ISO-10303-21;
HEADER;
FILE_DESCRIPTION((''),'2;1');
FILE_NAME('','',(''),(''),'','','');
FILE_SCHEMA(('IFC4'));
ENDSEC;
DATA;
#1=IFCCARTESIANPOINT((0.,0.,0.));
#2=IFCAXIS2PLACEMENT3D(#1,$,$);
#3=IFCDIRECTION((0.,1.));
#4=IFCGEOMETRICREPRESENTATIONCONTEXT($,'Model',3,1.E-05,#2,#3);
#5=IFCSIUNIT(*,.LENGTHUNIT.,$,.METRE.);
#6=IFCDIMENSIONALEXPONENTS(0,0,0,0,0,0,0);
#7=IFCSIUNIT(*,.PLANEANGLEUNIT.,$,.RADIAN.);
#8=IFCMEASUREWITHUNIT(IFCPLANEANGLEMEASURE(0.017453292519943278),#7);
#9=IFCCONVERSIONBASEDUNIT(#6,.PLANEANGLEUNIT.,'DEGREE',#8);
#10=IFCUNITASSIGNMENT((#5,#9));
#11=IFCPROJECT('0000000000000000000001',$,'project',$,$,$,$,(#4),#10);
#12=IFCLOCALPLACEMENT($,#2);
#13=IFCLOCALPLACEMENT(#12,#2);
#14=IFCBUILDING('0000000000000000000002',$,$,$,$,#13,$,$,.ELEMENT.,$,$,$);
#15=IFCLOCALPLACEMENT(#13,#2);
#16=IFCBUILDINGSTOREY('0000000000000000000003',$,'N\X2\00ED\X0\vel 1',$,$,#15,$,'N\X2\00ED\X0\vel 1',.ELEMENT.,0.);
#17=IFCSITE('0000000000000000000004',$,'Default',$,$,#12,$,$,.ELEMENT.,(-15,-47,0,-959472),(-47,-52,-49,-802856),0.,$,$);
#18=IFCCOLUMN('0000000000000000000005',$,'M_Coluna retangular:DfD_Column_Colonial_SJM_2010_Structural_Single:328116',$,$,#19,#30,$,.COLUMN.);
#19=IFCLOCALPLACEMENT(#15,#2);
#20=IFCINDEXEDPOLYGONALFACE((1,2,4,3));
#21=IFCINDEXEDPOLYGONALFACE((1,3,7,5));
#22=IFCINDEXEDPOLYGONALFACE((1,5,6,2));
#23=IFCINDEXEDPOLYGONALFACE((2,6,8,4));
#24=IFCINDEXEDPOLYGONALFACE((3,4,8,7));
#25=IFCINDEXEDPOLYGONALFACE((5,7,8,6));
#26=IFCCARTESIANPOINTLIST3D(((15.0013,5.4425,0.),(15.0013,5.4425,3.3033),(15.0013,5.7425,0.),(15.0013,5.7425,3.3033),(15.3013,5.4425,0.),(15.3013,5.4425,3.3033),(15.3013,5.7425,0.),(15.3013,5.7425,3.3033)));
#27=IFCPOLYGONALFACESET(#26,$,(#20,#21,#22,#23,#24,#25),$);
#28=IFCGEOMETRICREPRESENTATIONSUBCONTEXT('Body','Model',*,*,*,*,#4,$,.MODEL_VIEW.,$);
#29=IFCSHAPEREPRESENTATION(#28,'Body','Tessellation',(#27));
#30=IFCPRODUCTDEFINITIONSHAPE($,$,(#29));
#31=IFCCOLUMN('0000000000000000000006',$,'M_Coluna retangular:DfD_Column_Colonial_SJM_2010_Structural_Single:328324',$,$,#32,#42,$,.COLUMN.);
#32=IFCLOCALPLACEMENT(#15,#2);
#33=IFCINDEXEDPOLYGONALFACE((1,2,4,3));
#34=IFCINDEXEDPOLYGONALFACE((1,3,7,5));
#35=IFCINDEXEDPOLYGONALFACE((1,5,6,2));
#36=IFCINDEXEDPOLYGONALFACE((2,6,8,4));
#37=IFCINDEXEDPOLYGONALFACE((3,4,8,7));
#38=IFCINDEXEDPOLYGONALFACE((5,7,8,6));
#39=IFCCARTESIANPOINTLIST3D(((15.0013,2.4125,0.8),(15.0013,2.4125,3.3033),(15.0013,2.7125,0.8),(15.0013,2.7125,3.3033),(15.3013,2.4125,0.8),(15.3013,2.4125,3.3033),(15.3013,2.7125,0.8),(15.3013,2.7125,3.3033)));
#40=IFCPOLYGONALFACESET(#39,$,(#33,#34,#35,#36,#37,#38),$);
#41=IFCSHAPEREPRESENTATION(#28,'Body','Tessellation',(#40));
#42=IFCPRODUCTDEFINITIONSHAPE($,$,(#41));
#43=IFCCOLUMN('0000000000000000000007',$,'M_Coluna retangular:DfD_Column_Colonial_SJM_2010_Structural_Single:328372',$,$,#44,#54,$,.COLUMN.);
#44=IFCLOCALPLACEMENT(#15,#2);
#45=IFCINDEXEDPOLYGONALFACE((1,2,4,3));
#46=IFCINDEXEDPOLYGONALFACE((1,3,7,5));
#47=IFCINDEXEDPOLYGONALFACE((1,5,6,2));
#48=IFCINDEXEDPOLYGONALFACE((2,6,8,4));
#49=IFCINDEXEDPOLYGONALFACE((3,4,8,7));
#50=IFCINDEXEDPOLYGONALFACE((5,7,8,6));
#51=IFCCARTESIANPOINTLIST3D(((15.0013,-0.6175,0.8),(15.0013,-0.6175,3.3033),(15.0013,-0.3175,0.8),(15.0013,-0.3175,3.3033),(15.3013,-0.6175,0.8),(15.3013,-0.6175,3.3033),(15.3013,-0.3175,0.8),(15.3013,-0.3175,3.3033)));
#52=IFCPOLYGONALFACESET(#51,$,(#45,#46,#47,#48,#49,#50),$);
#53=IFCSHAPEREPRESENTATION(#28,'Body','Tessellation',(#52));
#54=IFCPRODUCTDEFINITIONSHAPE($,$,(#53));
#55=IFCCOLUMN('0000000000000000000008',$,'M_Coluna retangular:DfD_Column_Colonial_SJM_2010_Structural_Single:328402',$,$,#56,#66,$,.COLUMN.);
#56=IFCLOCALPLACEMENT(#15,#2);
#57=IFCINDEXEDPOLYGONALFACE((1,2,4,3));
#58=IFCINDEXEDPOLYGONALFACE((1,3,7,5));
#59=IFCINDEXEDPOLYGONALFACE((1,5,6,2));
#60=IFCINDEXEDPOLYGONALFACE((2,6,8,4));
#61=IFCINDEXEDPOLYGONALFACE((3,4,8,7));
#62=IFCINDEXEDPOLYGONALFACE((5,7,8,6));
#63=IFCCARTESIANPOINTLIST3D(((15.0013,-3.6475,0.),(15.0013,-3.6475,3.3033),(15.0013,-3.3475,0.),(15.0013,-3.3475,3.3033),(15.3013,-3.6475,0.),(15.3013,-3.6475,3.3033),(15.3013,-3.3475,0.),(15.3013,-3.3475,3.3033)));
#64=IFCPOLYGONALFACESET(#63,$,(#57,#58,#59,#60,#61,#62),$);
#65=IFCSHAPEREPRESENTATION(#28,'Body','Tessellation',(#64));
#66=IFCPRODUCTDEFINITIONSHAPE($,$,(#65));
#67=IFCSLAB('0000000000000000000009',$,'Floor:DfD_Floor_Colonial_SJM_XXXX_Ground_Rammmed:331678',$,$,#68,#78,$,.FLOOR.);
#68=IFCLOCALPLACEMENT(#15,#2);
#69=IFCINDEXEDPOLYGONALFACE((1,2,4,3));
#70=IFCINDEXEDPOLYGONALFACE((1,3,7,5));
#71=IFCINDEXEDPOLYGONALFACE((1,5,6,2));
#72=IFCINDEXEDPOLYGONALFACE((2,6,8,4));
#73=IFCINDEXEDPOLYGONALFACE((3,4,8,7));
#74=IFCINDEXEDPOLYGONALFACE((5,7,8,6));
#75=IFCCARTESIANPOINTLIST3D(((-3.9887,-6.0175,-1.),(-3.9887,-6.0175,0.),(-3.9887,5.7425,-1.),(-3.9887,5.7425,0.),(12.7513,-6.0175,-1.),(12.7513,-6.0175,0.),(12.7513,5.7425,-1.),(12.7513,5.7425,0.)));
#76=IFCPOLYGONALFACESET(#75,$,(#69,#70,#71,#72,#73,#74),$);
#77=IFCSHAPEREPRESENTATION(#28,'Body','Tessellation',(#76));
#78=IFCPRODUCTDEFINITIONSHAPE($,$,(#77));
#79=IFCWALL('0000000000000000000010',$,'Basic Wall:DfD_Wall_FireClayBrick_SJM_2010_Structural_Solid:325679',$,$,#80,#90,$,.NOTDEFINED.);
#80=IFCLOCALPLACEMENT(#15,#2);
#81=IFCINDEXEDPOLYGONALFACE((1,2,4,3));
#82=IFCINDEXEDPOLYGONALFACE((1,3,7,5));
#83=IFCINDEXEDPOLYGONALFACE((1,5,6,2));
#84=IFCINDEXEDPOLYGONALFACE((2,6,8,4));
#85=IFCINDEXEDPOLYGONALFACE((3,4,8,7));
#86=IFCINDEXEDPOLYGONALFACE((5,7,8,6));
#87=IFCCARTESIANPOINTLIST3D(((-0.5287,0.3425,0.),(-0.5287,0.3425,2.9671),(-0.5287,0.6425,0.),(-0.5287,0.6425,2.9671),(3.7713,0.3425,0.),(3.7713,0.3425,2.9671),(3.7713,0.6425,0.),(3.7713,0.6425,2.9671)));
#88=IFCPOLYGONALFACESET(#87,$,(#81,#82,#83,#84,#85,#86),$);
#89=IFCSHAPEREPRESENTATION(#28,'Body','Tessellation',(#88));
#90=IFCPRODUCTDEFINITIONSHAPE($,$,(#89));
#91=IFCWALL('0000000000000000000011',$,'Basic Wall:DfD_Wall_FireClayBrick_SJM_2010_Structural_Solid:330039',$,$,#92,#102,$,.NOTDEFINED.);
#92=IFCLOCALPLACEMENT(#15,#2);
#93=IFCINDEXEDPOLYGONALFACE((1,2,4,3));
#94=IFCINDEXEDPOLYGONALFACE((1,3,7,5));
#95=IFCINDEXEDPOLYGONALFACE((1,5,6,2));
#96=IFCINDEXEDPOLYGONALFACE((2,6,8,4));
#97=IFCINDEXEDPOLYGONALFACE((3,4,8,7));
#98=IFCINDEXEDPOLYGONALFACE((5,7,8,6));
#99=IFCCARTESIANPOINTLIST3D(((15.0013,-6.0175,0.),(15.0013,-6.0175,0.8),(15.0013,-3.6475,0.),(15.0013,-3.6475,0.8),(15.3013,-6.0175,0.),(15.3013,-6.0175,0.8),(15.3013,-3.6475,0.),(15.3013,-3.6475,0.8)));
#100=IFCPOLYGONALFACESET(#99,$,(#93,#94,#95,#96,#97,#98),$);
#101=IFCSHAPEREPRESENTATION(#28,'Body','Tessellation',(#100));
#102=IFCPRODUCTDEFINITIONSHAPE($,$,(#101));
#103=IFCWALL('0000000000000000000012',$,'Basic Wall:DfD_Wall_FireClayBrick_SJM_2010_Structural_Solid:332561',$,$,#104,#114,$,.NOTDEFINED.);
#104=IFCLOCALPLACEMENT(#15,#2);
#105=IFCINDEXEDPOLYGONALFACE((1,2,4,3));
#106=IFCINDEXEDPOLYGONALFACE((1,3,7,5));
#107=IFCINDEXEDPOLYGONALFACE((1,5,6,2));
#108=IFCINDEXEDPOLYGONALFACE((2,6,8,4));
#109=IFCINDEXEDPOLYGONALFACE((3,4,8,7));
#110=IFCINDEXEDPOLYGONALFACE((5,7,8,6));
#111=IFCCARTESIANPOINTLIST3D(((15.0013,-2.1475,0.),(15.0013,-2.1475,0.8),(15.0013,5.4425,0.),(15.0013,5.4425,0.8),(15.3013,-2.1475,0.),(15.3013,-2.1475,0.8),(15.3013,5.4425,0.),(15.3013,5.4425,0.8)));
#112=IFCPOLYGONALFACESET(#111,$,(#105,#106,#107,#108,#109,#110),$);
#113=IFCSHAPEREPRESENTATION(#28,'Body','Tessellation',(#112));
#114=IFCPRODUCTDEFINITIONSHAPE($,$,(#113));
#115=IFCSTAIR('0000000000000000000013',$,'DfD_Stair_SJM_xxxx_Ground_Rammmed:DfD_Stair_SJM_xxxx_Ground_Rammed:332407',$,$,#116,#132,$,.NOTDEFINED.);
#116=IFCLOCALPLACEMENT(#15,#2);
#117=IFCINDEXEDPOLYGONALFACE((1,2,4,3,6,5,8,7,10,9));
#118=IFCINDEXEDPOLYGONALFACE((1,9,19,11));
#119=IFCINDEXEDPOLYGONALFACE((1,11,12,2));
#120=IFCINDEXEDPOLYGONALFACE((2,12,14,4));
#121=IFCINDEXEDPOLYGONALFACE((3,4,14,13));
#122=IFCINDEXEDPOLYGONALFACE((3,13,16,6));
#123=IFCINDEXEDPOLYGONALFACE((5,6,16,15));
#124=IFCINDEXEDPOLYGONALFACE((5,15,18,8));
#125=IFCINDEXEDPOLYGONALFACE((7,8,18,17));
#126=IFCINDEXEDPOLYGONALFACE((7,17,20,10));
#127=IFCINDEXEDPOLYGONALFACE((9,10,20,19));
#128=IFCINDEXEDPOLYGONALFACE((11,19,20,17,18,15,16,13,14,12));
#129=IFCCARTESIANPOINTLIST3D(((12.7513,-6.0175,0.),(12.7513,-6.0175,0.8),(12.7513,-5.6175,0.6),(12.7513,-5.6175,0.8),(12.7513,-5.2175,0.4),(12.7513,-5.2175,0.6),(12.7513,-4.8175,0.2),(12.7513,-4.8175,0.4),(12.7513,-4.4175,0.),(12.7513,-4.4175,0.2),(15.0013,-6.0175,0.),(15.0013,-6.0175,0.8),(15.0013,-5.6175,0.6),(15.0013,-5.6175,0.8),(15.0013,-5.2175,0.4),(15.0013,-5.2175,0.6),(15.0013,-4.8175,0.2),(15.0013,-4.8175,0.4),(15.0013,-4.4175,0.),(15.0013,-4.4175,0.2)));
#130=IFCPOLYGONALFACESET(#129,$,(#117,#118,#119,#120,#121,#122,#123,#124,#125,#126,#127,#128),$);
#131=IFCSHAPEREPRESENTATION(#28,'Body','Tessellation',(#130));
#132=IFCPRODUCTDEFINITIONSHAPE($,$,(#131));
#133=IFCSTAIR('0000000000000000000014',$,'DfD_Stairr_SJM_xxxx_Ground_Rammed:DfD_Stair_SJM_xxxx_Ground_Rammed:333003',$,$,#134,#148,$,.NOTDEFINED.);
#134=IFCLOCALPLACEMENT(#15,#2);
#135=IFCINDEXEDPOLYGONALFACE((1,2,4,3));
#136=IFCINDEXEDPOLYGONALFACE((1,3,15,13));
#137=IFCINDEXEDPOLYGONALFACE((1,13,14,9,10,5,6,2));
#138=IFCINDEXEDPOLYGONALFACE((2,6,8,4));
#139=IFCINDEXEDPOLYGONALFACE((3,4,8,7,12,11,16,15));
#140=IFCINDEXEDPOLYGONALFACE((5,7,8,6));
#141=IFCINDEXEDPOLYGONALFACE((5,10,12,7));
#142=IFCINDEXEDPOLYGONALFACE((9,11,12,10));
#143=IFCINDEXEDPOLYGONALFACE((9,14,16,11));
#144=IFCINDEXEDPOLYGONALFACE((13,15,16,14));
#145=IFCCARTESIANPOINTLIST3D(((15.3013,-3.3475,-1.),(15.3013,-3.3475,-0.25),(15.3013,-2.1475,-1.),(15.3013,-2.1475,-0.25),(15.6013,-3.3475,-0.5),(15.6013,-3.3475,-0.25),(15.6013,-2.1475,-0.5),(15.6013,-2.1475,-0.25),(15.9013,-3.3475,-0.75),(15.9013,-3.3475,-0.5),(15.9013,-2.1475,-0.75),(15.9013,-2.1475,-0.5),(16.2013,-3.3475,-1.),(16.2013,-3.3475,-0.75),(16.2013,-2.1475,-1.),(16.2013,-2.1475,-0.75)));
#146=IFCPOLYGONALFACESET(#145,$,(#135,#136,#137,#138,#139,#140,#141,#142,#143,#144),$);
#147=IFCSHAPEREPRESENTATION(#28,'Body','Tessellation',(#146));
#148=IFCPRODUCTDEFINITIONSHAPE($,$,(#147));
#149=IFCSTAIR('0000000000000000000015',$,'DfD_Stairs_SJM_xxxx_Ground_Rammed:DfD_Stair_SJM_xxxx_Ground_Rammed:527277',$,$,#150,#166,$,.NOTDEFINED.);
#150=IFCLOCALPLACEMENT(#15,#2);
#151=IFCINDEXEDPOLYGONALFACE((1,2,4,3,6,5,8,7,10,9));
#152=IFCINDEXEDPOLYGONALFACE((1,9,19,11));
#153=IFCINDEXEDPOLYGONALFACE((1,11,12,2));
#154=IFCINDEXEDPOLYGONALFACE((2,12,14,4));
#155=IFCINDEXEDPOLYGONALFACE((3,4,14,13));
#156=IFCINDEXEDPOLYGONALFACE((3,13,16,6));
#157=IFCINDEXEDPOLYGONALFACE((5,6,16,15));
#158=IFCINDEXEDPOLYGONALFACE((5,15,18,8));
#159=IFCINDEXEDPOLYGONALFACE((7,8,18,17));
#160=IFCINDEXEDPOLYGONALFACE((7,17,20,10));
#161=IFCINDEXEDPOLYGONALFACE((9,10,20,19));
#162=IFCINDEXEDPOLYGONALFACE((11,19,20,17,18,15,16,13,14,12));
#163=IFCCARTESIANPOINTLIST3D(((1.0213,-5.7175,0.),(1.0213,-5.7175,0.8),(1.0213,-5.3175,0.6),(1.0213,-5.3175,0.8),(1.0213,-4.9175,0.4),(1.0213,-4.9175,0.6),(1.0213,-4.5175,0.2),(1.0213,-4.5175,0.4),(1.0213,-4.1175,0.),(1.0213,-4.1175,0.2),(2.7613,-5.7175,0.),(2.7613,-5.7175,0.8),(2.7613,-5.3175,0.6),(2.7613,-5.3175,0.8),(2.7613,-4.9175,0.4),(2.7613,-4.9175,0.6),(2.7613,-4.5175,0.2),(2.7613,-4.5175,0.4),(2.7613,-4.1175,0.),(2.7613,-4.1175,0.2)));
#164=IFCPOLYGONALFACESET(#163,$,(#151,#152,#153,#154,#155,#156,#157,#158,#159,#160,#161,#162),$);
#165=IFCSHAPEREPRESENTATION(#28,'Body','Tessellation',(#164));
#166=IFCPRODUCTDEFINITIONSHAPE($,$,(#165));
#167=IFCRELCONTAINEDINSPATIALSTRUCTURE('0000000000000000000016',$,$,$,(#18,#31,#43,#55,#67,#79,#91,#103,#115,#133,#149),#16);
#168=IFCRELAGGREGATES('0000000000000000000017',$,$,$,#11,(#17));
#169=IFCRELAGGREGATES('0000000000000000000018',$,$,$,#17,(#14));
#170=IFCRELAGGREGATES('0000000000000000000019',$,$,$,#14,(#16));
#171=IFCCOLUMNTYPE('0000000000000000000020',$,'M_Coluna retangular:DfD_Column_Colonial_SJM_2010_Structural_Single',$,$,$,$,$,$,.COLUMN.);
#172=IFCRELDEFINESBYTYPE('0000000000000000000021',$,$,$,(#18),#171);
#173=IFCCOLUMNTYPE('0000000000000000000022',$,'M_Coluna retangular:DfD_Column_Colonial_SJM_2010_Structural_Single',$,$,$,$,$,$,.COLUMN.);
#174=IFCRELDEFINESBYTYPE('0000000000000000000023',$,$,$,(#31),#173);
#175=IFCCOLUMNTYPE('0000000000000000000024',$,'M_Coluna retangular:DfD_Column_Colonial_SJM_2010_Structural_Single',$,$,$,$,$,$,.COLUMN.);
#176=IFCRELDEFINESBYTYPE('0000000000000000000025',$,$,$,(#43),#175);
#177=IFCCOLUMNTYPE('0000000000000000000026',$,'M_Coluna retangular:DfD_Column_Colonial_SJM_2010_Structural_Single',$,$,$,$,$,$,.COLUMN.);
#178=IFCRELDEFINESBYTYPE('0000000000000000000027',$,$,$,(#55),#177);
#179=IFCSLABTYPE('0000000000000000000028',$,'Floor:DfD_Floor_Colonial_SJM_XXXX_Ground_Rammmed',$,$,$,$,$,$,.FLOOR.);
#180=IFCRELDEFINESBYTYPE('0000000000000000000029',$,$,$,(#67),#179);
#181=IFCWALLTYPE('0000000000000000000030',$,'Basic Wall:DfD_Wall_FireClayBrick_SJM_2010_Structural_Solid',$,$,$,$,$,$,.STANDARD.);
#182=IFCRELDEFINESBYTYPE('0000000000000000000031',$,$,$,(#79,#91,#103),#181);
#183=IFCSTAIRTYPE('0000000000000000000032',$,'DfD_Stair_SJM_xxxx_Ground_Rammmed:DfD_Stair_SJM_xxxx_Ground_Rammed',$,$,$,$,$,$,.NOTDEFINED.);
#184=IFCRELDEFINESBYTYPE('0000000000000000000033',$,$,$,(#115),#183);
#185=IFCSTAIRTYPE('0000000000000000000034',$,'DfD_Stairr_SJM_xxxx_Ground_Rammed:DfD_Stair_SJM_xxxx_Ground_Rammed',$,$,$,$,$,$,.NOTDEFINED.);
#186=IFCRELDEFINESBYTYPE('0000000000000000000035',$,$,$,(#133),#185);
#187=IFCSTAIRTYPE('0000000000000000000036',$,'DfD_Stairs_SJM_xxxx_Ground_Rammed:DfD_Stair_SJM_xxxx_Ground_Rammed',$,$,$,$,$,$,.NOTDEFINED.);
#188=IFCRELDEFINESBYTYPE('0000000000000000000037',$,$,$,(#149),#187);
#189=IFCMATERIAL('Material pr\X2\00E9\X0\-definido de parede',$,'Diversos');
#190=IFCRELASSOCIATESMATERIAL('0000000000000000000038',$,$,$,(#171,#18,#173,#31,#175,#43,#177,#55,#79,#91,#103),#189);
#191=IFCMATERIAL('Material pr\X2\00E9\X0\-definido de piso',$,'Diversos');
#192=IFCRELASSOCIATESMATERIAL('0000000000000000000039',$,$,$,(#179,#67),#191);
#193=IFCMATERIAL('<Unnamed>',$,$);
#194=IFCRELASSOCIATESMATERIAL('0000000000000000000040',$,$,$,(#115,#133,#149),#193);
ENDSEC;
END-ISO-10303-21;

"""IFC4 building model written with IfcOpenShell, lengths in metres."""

from ifc_helpers import new_model, entity, si_unit, converted_unit, direction, frame, origin, place, context, subcontext, project, spatial, indexed_curve, outline, extrude, source, transform, mapped, material, type_object, type_shapes, element, save


model = new_model("IFC4")

# Units and contexts
model_context = context("Model", 3, precision=1e-05, world=origin(), true_north=direction((0.0, 1.0)))
body_context = subcontext(model_context, "Body", "Model", "MODEL_VIEW")
ifc_project = project(units=[si_unit("LENGTHUNIT", "METRE"), converted_unit("PLANEANGLEUNIT", "DEGREE", entity("IfcPlaneAngleMeasure", 0.017453292519943278), si_unit("PLANEANGLEUNIT", "RADIAN"), dimensions=[0, 0, 0, 0, 0, 0, 0])], contexts=[model_context])

# Site, building, storey
site_placement = place(None, origin())
site = spatial("IfcSite", under=ifc_project, at=site_placement, Name="Default", CompositionType="ELEMENT", RefLatitude=(-15, -47, 0, -959472), RefLongitude=(-47, -52, -49, -802856), RefElevation=0.0)
building_placement = place(site_placement, origin())
building = spatial("IfcBuilding", under=site, at=building_placement, CompositionType="ELEMENT")
storey_placement = place(building_placement, origin())
storey = spatial("IfcBuildingStorey", under=building, at=storey_placement, Name="Nível 1", LongName="Nível 1", CompositionType="ELEMENT", Elevation=0.0)

# Columns
ifc_material_1 = material(Name="Material pré-definido de parede", Category="Diversos")
column_type_1 = type_object("IfcColumnType", Name="M_Coluna retangular:DfD_Column_Colonial_SJM_2010_Structural_Single", PredefinedType="COLUMN", material=ifc_material_1)
shared_shape_1 = source(origin(), body_context, "Body", "SweptSolid", [
    extrude(outline(indexed_curve([(-0.15, -0.15), (0.15, -0.15), (0.15, 0.15), (-0.15, 0.15), (-0.15, -0.15)], self_intersect=False)), frame((15.1513, 5.5925, 0.0), z_axis=(0.0, 0.0, 1.0), x_axis=(-1.0, 0.0, 0.0)), (0.0, 0.0, 1.0), 3.3033),
])
type_shapes(column_type_1, [shared_shape_1])
column_1_placement = place(storey_placement, origin())
element("IfcColumn", 1, at=column_1_placement, inside=storey, type_object=column_type_1, material=ifc_material_1, Name="M_Coluna retangular:DfD_Column_Colonial_SJM_2010_Structural_Single:328116", PredefinedType="COLUMN", context=body_context, shape_type="MappedRepresentation", body=[
    mapped(shared_shape_1, transform((0.0, 0.0, 0.0), scale=1.0)),
])
column_type_2 = type_object("IfcColumnType", Name="M_Coluna retangular:DfD_Column_Colonial_SJM_2010_Structural_Single", PredefinedType="COLUMN", material=ifc_material_1)
shared_shape_2 = source(origin(), body_context, "Body", "SweptSolid", [
    extrude(outline(indexed_curve([(-0.15, -0.15), (0.15, -0.15), (0.15, 0.15), (-0.15, 0.15), (-0.15, -0.15)], self_intersect=False)), frame((15.1513, 2.5625, 0.8), z_axis=(0.0, 0.0, 1.0), x_axis=(0.0, -1.0, 0.0)), (0.0, 0.0, 1.0), 2.5033),
])
type_shapes(column_type_2, [shared_shape_2])
column_2_placement = place(storey_placement, origin())
element("IfcColumn", 2, at=column_2_placement, inside=storey, type_object=column_type_2, material=ifc_material_1, Name="M_Coluna retangular:DfD_Column_Colonial_SJM_2010_Structural_Single:328324", PredefinedType="COLUMN", context=body_context, shape_type="MappedRepresentation", body=[
    mapped(shared_shape_2, transform((0.0, 0.0, 0.0), scale=1.0)),
])
column_type_3 = type_object("IfcColumnType", Name="M_Coluna retangular:DfD_Column_Colonial_SJM_2010_Structural_Single", PredefinedType="COLUMN", material=ifc_material_1)
shared_shape_3 = source(origin(), body_context, "Body", "SweptSolid", [
    extrude(outline(indexed_curve([(-0.15, -0.15), (0.15, -0.15), (0.15, 0.15), (-0.15, 0.15), (-0.15, -0.15)], self_intersect=False)), frame((15.1513, -0.4675, 0.8), z_axis=(0.0, 0.0, 1.0), x_axis=(0.0, -1.0, 0.0)), (0.0, 0.0, 1.0), 2.5033),
])
type_shapes(column_type_3, [shared_shape_3])
column_3_placement = place(storey_placement, origin())
element("IfcColumn", 3, at=column_3_placement, inside=storey, type_object=column_type_3, material=ifc_material_1, Name="M_Coluna retangular:DfD_Column_Colonial_SJM_2010_Structural_Single:328372", PredefinedType="COLUMN", context=body_context, shape_type="MappedRepresentation", body=[
    mapped(shared_shape_3, transform((0.0, 0.0, 0.0), scale=1.0)),
])
column_type_4 = type_object("IfcColumnType", Name="M_Coluna retangular:DfD_Column_Colonial_SJM_2010_Structural_Single", PredefinedType="COLUMN", material=ifc_material_1)
shared_shape_4 = source(origin(), body_context, "Body", "SweptSolid", [
    extrude(outline(indexed_curve([(-0.15, -0.15), (0.15, -0.15), (0.15, 0.15), (-0.15, 0.15), (-0.15, -0.15)], self_intersect=False)), frame((15.1513, -3.4975, 0.0), z_axis=(0.0, 0.0, 1.0), x_axis=(-1.0, 0.0, 0.0)), (0.0, 0.0, 1.0), 3.3033),
])
type_shapes(column_type_4, [shared_shape_4])
column_4_placement = place(storey_placement, origin())
element("IfcColumn", 4, at=column_4_placement, inside=storey, type_object=column_type_4, material=ifc_material_1, Name="M_Coluna retangular:DfD_Column_Colonial_SJM_2010_Structural_Single:328402", PredefinedType="COLUMN", context=body_context, shape_type="MappedRepresentation", body=[
    mapped(shared_shape_4, transform((0.0, 0.0, 0.0), scale=1.0)),
])

# Slab
ifc_material_2 = material(Name="Material pré-definido de piso", Category="Diversos")
slab_type = type_object("IfcSlabType", Name="Floor:DfD_Floor_Colonial_SJM_XXXX_Ground_Rammmed", PredefinedType="FLOOR", material=ifc_material_2)
slab_1_placement = place(storey_placement, origin())
element("IfcSlab", 5, at=slab_1_placement, inside=storey, type_object=slab_type, material=ifc_material_2, Name="Floor:DfD_Floor_Colonial_SJM_XXXX_Ground_Rammmed:331678", PredefinedType="FLOOR", context=body_context, shape_type="SweptSolid", body=[
    extrude(outline(indexed_curve([(-5.88, -8.37), (5.88, -8.37), (5.88, 8.37), (-5.88, 8.37), (-5.88, -8.37)], self_intersect=False)), frame((4.3813, -0.1375, 0.0), z_axis=(0.0, 0.0, -1.0), x_axis=(0.0, 1.0, 0.0)), (0.0, 0.0, 1.0), 1.0),
])

# Walls
wall_type = type_object("IfcWallType", Name="Basic Wall:DfD_Wall_FireClayBrick_SJM_2010_Structural_Solid", PredefinedType="STANDARD")
wall_1_placement = place(storey_placement, frame((-0.5287, 0.4925, 0.0)))
element("IfcWall", 6, at=wall_1_placement, inside=storey, type_object=wall_type, material=ifc_material_1, Name="Basic Wall:DfD_Wall_FireClayBrick_SJM_2010_Structural_Solid:325679", PredefinedType="NOTDEFINED", context=body_context, shape_type="SweptSolid", body=[
    extrude(outline(indexed_curve([(4.3, 0.15), (0.0, 0.15), (0.0, -0.15), (4.3, -0.15), (4.3, 0.15)], self_intersect=False)), origin(), (0.0, 0.0, 1.0), 2.9671),
])
wall_2_placement = place(storey_placement, frame((15.1513, -6.0175, 0.0), z_axis=(0.0, 0.0, 1.0), x_axis=(0.0, 1.0, 0.0)))
element("IfcWall", 7, at=wall_2_placement, inside=storey, type_object=wall_type, material=ifc_material_1, Name="Basic Wall:DfD_Wall_FireClayBrick_SJM_2010_Structural_Solid:330039", PredefinedType="NOTDEFINED", context=body_context, shape_type="SweptSolid", body=[
    extrude(outline(indexed_curve([(2.37, 0.15), (0.0, 0.15), (0.0, -0.15), (2.37, -0.15), (2.37, 0.15)], self_intersect=False)), origin(), (0.0, 0.0, 1.0), 0.8),
])
wall_3_placement = place(storey_placement, frame((15.1513, -2.1475, 0.0), z_axis=(0.0, 0.0, 1.0), x_axis=(0.0, 1.0, 0.0)))
element("IfcWall", 8, at=wall_3_placement, inside=storey, type_object=wall_type, material=ifc_material_1, Name="Basic Wall:DfD_Wall_FireClayBrick_SJM_2010_Structural_Solid:332561", PredefinedType="NOTDEFINED", context=body_context, shape_type="SweptSolid", body=[
    extrude(outline(indexed_curve([(7.59, 0.15), (0.0, 0.15), (0.0, -0.15), (7.59, -0.15), (7.59, 0.15)], self_intersect=False)), origin(), (0.0, 0.0, 1.0), 0.8),
])

# Stairs
ifc_material_3 = material(Name="<Unnamed>")
stair_type_1 = type_object("IfcStairType", Name="DfD_Stair_SJM_xxxx_Ground_Rammmed:DfD_Stair_SJM_xxxx_Ground_Rammed", PredefinedType="NOTDEFINED")
stair_1_placement = place(storey_placement, origin())
element("IfcStair", 9, at=stair_1_placement, inside=storey, type_object=stair_type_1, material=ifc_material_3, Name="DfD_Stair_SJM_xxxx_Ground_Rammmed:DfD_Stair_SJM_xxxx_Ground_Rammed:332407", PredefinedType="NOTDEFINED", context=body_context, shape_type="SweptSolid", body=[
    extrude(outline(indexed_curve([(-0.8, -0.4), (0.8, -0.4), (0.8, -0.2), (0.4, -0.2), (0.4, 0.0), (0.0, 0.0), (0.0, 0.2), (-0.4, 0.2), (-0.4, 0.4), (-0.8, 0.4), (-0.8, -0.4)], self_intersect=False)), frame((12.7513, -5.2175, 0.4), z_axis=(1.0, 0.0, 0.0), x_axis=(0.0, 1.0, 0.0)), (0.0, 0.0, 1.0), 2.25),
])
stair_type_2 = type_object("IfcStairType", Name="DfD_Stairr_SJM_xxxx_Ground_Rammed:DfD_Stair_SJM_xxxx_Ground_Rammed", PredefinedType="NOTDEFINED")
stair_2_placement = place(storey_placement, origin())
element("IfcStair", 10, at=stair_2_placement, inside=storey, type_object=stair_type_2, material=ifc_material_3, Name="DfD_Stairr_SJM_xxxx_Ground_Rammed:DfD_Stair_SJM_xxxx_Ground_Rammed:333003", PredefinedType="NOTDEFINED", context=body_context, shape_type="SweptSolid", body=[
    extrude(outline(indexed_curve([(-0.375, -0.45), (0.375, -0.45), (0.375, -0.15), (0.125, -0.15), (0.125, 0.15), (-0.125, 0.15), (-0.125, 0.45), (-0.375, 0.45), (-0.375, -0.45)], self_intersect=False)), frame((15.7513, -3.3475, -0.625), z_axis=(0.0, 1.0, 0.0), x_axis=(0.0, 0.0, 1.0)), (0.0, 0.0, 1.0), 1.2),
])
stair_type_3 = type_object("IfcStairType", Name="DfD_Stairs_SJM_xxxx_Ground_Rammed:DfD_Stair_SJM_xxxx_Ground_Rammed", PredefinedType="NOTDEFINED")
stair_3_placement = place(storey_placement, origin())
element("IfcStair", 11, at=stair_3_placement, inside=storey, type_object=stair_type_3, material=ifc_material_3, Name="DfD_Stairs_SJM_xxxx_Ground_Rammed:DfD_Stair_SJM_xxxx_Ground_Rammed:527277", PredefinedType="NOTDEFINED", context=body_context, shape_type="SweptSolid", body=[
    extrude(outline(indexed_curve([(-0.8, -0.4), (0.8, -0.4), (0.8, -0.2), (0.4, -0.2), (0.4, 0.0), (0.0, 0.0), (0.0, 0.2), (-0.4, 0.2), (-0.4, 0.4), (-0.8, 0.4), (-0.8, -0.4)], self_intersect=False)), frame((1.0213, -4.9175, 0.4), z_axis=(1.0, 0.0, 0.0), x_axis=(0.0, 1.0, 0.0)), (0.0, 0.0, 1.0), 1.74),
])

save(model, "model.ifc")
